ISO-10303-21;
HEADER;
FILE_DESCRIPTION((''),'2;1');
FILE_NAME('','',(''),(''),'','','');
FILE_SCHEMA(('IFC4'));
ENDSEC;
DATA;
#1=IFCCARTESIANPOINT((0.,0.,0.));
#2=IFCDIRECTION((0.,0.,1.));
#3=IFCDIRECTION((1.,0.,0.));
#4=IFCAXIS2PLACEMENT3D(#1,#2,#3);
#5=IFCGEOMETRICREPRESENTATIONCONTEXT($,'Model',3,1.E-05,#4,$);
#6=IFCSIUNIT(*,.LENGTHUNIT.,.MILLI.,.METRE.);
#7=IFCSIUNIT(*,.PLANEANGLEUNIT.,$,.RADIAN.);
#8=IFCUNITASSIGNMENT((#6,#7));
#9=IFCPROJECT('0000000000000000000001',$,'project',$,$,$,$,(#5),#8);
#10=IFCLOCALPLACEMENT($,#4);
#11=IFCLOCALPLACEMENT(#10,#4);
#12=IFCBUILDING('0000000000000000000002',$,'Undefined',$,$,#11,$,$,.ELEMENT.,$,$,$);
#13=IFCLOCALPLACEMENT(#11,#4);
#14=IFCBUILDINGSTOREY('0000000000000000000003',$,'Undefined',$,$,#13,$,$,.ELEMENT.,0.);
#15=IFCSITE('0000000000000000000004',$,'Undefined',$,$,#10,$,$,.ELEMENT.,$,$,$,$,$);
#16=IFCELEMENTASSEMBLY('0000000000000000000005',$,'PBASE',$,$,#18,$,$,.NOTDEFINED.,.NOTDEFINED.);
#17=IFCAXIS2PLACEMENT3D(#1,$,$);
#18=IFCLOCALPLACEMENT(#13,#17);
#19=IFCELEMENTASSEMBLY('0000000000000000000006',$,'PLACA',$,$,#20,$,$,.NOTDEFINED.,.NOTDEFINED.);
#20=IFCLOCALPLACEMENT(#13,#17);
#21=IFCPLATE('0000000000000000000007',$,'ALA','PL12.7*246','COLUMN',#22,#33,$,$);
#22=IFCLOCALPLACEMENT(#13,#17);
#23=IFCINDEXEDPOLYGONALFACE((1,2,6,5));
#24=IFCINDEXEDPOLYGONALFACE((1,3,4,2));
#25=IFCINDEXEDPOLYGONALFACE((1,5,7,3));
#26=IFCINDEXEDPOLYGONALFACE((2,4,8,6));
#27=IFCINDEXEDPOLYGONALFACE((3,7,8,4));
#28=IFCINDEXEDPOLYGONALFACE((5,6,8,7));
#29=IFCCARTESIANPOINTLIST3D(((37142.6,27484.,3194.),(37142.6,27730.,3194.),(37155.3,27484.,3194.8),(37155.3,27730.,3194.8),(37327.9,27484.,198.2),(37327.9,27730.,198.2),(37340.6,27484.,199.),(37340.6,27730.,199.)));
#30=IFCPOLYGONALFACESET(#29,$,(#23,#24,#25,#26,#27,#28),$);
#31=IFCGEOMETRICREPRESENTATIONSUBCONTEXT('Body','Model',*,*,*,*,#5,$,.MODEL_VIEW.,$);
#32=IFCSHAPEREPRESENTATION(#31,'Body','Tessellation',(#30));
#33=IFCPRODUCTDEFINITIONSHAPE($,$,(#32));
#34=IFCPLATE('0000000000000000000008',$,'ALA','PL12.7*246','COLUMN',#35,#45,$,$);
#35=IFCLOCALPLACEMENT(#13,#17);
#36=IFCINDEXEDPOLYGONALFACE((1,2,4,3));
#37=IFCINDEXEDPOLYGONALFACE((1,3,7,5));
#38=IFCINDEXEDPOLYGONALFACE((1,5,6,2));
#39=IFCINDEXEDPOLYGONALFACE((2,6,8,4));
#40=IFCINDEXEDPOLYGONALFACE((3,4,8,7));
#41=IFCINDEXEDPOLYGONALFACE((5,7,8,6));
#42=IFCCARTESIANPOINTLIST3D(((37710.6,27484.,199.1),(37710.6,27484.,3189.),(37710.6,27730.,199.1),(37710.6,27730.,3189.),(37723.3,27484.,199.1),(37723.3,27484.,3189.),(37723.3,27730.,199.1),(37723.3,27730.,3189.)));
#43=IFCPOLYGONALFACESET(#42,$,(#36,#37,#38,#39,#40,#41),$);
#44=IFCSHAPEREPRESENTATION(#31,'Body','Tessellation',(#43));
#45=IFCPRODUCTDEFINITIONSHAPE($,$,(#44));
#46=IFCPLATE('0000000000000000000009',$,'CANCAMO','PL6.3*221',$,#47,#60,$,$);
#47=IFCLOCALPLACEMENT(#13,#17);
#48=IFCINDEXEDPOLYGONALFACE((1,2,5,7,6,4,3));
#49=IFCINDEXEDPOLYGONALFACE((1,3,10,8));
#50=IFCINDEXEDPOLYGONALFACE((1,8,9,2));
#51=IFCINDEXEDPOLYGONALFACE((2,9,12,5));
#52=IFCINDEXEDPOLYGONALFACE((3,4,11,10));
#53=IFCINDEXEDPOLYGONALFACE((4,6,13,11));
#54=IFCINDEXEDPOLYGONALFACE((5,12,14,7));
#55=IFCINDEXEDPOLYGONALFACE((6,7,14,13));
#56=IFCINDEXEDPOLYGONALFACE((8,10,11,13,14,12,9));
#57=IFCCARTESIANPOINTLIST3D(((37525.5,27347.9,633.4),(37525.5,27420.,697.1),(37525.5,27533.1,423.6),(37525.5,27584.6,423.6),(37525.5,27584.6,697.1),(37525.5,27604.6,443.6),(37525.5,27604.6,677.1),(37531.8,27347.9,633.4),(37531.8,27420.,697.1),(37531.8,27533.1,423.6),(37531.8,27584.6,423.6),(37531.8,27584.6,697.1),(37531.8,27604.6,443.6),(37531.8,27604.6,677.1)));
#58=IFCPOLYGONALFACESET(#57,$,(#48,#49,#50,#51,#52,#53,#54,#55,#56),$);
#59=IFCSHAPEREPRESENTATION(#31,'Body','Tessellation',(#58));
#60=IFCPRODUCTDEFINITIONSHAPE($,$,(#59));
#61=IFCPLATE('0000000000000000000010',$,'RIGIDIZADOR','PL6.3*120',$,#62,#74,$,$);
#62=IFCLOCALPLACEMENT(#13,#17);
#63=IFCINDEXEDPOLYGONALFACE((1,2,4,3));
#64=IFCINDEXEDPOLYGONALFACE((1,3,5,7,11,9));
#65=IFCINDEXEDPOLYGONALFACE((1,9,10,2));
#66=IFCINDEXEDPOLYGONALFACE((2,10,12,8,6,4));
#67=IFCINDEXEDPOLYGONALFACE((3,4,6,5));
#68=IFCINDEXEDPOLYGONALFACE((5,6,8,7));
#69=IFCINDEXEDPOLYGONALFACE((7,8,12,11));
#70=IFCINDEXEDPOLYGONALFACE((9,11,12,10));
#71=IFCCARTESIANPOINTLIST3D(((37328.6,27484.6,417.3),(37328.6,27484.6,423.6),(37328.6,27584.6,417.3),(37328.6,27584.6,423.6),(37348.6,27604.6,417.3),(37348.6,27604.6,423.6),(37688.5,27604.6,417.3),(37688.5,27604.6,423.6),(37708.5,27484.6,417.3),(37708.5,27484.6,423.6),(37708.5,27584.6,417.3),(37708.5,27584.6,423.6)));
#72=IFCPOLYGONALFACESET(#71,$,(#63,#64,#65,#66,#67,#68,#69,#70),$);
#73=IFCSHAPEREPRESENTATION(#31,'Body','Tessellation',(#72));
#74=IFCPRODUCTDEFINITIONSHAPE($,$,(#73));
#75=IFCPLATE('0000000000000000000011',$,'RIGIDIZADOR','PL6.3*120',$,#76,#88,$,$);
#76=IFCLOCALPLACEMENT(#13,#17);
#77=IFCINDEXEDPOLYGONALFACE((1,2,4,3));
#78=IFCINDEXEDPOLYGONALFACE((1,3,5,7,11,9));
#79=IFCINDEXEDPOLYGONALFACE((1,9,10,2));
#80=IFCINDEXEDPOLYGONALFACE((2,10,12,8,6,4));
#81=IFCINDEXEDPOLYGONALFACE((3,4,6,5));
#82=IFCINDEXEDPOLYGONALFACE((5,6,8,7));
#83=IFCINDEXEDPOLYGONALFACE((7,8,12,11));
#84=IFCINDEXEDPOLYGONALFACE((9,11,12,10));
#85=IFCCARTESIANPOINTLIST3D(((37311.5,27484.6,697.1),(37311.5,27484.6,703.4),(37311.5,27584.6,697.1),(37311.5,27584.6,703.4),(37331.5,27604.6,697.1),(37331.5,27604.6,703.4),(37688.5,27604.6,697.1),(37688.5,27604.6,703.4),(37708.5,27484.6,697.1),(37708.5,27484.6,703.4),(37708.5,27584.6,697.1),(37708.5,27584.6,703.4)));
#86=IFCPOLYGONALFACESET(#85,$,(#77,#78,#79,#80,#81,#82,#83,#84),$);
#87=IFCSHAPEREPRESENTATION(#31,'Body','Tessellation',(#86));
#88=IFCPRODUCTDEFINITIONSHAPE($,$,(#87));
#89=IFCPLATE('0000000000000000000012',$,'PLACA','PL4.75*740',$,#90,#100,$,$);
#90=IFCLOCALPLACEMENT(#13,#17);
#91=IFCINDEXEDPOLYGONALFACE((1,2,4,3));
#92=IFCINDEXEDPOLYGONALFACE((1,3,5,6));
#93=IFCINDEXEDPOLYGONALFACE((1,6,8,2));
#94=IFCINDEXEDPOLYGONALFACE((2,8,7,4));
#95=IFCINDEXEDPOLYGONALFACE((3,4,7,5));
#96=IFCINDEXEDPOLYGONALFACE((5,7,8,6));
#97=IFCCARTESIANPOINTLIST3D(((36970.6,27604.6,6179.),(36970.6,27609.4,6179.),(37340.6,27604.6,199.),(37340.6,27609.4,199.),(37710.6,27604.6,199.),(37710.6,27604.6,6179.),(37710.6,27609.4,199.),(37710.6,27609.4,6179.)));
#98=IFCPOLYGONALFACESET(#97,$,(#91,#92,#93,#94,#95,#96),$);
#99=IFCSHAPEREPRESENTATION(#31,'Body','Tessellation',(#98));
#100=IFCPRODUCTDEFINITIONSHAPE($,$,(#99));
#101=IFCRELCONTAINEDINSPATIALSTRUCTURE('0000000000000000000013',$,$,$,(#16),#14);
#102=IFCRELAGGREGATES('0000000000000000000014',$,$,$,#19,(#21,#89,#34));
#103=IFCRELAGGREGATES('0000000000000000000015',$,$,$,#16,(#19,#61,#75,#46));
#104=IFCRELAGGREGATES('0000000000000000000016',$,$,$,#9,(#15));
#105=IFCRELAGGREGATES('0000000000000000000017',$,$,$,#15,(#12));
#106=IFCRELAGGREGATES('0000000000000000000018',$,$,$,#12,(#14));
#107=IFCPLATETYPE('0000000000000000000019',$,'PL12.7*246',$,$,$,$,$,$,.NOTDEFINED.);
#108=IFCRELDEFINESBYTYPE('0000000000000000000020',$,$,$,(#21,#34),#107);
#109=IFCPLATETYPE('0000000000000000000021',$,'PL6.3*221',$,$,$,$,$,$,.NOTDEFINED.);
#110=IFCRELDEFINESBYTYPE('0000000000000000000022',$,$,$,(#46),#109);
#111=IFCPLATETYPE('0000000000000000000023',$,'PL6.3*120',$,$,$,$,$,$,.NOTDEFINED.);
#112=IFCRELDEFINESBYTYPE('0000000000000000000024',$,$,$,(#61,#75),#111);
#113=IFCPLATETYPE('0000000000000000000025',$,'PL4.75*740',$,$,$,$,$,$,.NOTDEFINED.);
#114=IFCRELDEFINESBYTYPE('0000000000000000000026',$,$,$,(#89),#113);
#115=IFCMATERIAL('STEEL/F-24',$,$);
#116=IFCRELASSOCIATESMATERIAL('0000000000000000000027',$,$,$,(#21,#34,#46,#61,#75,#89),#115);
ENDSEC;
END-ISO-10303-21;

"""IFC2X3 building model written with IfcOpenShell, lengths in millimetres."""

from ifc_helpers import new_model, si_unit, frame, origin_with_axes, place, context, subcontext, project, spatial, polyline, outline, extrude, material, type_object, element, aggregate, save


model = new_model("IFC2X3")

# Units and contexts
model_context = context("Model", 3, precision=1e-05, world=origin_with_axes())
body_context = subcontext(model_context, "Body", "Model", "MODEL_VIEW")
ifc_project = project(units=[si_unit("LENGTHUNIT", "METRE", prefix="MILLI"), si_unit("PLANEANGLEUNIT", "RADIAN")], contexts=[model_context])

# Site, building, storey
site_placement = place(None, origin_with_axes())
site = spatial("IfcSite", under=ifc_project, at=site_placement, Name="Undefined", CompositionType="ELEMENT")
building_placement = place(site_placement, origin_with_axes())
building = spatial("IfcBuilding", under=site, at=building_placement, Name="Undefined", CompositionType="ELEMENT")
storey_placement = place(building_placement, origin_with_axes())
storey = spatial("IfcBuildingStorey", under=building, at=storey_placement, Name="Undefined", CompositionType="ELEMENT", Elevation=0.0)

# Shared definitions
ifc_material_1 = material(Name="STEEL/F-24")

# Element assemblies, plates
assembly_1_placement = place(storey_placement, origin_with_axes())
assembly_1 = element("IfcElementAssembly", 1, at=assembly_1_placement, inside=storey, Name="PBASE", AssemblyPlace="NOTDEFINED", PredefinedType="NOTDEFINED")
assembly_2_placement = place(assembly_1_placement, origin_with_axes())
assembly_2 = element("IfcElementAssembly", 2, at=assembly_2_placement, Name="PLACA", AssemblyPlace="NOTDEFINED", PredefinedType="NOTDEFINED")
plate_type_1 = type_object("IfcPlateType", Name="PL12.7*246", PredefinedType="NOTDEFINED")
plate_1_placement = place(assembly_2_placement, frame((37334.3, 27607.0, 198.6), z_axis=(-0.998091, 0.0, -0.061754), x_axis=(-0.061754, 0.0, 0.998091)))
plate_1 = element("IfcPlate", 3, at=plate_1_placement, type_object=plate_type_1, material=ifc_material_1, Name="ALA", Description="PL12.7*246", ObjectType="COLUMN", context=body_context, shape_type="SweptSolid", body=[
    extrude(outline(polyline([(0.0, -123.0), (0.0, 123.0), (3001.5, 123.0), (3001.5, -123.0), (0.0, -123.0)])), frame((0.0, 0.0, -6.3), z_axis=(0.0, 0.0, 1.0), x_axis=(1.0, 0.0, 0.0)), (0.0, 0.0, 1.0), 12.7),
])
plate_2_placement = place(assembly_2_placement, frame((37717.0, 27607.0, 199.1), z_axis=(-1.0, 0.0, -0.000009), x_axis=(-0.000009, 0.0, 1.0)))
plate_2 = element("IfcPlate", 4, at=plate_2_placement, type_object=plate_type_1, material=ifc_material_1, Name="ALA", Description="PL12.7*246", ObjectType="COLUMN", context=body_context, shape_type="SweptSolid", body=[
    extrude(outline(polyline([(0.0, -123.0), (0.0, 123.0), (2990.0, 123.0), (2990.0, -123.0), (0.0, -123.0)])), frame((0.0, 0.0, -6.3), z_axis=(0.0, 0.0, 1.0), x_axis=(1.0, 0.0, 0.0)), (0.0, 0.0, 1.0), 12.7),
])
plate_type_2 = type_object("IfcPlateType", Name="PL6.3*221", PredefinedType="NOTDEFINED")
plate_3_placement = place(assembly_1_placement, frame((37528.7, 27604.6, 423.6), z_axis=(1.0, 0.0, 0.0), x_axis=(0.0, 0.0, 1.0)))
plate_3 = element("IfcPlate", 5, at=plate_3_placement, type_object=plate_type_2, material=ifc_material_1, Name="CANCAMO", Description="PL6.3*221", context=body_context, shape_type="SweptSolid", body=[
    extrude(outline(polyline([(0.0, 20.0), (20.0, 0.0), (253.4, 0.0), (273.4, 20.0), (273.4, 184.6), (209.8, 256.7), (0.0, 71.5), (0.0, 20.0)])), frame((0.0, 0.0, -3.1), z_axis=(0.0, 0.0, 1.0), x_axis=(1.0, 0.0, 0.0)), (0.0, 0.0, 1.0), 6.3),
])
plate_type_3 = type_object("IfcPlateType", Name="PL6.3*120", PredefinedType="NOTDEFINED")
plate_4_placement = place(assembly_1_placement, frame((37708.5, 27604.6, 420.5), z_axis=(0.0, 0.0, -1.0), x_axis=(0.0, -1.0, 0.0)))
plate_4 = element("IfcPlate", 6, at=plate_4_placement, type_object=plate_type_3, material=ifc_material_1, Name="RIGIDIZADOR", Description="PL6.3*120", context=body_context, shape_type="SweptSolid", body=[
    extrude(outline(polyline([(0.0, 20.0), (20.0, 0.0), (120.0, 0.0), (120.0, 379.9), (20.0, 379.9), (0.0, 359.9), (0.0, 20.0)])), frame((0.0, 0.0, -3.1), z_axis=(0.0, 0.0, 1.0), x_axis=(1.0, 0.0, 0.0)), (0.0, 0.0, 1.0), 6.3),
])
plate_5_placement = place(assembly_1_placement, frame((37708.5, 27604.6, 700.2), z_axis=(0.0, 0.0, -1.0), x_axis=(0.0, -1.0, 0.0)))
plate_5 = element("IfcPlate", 7, at=plate_5_placement, type_object=plate_type_3, material=ifc_material_1, Name="RIGIDIZADOR", Description="PL6.3*120", context=body_context, shape_type="SweptSolid", body=[
    extrude(outline(polyline([(0.0, 20.0), (20.0, 0.0), (120.0, 0.0), (120.0, 397.0), (20.0, 397.0), (0.0, 377.0), (0.0, 20.0)])), frame((0.0, 0.0, -3.1), z_axis=(0.0, 0.0, 1.0), x_axis=(1.0, 0.0, 0.0)), (0.0, 0.0, 1.0), 6.3),
])
plate_type_4 = type_object("IfcPlateType", Name="PL4.75*740", PredefinedType="NOTDEFINED")
plate_6_placement = place(assembly_2_placement, frame((37710.6, 27607.0, 199.0), z_axis=(0.0, -1.0, 0.0), x_axis=(0.0, 0.0, 1.0)))
plate_6 = element("IfcPlate", 8, at=plate_6_placement, type_object=plate_type_4, material=ifc_material_1, Name="PLACA", Description="PL4.75*740", context=body_context, shape_type="SweptSolid", body=[
    extrude(outline(polyline([(0.0, 0.0), (5980.0, 0.0), (5980.0, 740.0), (0.0, 370.0), (0.0, 0.0)])), frame((0.0, 0.0, -2.4), z_axis=(0.0, 0.0, 1.0), x_axis=(1.0, 0.0, 0.0)), (0.0, 0.0, 1.0), 4.8),
])
aggregate(assembly_2, [plate_1, plate_6, plate_2])

aggregate(assembly_1, [assembly_2, plate_4, plate_5, plate_3])

save(model, "model.ifc")
